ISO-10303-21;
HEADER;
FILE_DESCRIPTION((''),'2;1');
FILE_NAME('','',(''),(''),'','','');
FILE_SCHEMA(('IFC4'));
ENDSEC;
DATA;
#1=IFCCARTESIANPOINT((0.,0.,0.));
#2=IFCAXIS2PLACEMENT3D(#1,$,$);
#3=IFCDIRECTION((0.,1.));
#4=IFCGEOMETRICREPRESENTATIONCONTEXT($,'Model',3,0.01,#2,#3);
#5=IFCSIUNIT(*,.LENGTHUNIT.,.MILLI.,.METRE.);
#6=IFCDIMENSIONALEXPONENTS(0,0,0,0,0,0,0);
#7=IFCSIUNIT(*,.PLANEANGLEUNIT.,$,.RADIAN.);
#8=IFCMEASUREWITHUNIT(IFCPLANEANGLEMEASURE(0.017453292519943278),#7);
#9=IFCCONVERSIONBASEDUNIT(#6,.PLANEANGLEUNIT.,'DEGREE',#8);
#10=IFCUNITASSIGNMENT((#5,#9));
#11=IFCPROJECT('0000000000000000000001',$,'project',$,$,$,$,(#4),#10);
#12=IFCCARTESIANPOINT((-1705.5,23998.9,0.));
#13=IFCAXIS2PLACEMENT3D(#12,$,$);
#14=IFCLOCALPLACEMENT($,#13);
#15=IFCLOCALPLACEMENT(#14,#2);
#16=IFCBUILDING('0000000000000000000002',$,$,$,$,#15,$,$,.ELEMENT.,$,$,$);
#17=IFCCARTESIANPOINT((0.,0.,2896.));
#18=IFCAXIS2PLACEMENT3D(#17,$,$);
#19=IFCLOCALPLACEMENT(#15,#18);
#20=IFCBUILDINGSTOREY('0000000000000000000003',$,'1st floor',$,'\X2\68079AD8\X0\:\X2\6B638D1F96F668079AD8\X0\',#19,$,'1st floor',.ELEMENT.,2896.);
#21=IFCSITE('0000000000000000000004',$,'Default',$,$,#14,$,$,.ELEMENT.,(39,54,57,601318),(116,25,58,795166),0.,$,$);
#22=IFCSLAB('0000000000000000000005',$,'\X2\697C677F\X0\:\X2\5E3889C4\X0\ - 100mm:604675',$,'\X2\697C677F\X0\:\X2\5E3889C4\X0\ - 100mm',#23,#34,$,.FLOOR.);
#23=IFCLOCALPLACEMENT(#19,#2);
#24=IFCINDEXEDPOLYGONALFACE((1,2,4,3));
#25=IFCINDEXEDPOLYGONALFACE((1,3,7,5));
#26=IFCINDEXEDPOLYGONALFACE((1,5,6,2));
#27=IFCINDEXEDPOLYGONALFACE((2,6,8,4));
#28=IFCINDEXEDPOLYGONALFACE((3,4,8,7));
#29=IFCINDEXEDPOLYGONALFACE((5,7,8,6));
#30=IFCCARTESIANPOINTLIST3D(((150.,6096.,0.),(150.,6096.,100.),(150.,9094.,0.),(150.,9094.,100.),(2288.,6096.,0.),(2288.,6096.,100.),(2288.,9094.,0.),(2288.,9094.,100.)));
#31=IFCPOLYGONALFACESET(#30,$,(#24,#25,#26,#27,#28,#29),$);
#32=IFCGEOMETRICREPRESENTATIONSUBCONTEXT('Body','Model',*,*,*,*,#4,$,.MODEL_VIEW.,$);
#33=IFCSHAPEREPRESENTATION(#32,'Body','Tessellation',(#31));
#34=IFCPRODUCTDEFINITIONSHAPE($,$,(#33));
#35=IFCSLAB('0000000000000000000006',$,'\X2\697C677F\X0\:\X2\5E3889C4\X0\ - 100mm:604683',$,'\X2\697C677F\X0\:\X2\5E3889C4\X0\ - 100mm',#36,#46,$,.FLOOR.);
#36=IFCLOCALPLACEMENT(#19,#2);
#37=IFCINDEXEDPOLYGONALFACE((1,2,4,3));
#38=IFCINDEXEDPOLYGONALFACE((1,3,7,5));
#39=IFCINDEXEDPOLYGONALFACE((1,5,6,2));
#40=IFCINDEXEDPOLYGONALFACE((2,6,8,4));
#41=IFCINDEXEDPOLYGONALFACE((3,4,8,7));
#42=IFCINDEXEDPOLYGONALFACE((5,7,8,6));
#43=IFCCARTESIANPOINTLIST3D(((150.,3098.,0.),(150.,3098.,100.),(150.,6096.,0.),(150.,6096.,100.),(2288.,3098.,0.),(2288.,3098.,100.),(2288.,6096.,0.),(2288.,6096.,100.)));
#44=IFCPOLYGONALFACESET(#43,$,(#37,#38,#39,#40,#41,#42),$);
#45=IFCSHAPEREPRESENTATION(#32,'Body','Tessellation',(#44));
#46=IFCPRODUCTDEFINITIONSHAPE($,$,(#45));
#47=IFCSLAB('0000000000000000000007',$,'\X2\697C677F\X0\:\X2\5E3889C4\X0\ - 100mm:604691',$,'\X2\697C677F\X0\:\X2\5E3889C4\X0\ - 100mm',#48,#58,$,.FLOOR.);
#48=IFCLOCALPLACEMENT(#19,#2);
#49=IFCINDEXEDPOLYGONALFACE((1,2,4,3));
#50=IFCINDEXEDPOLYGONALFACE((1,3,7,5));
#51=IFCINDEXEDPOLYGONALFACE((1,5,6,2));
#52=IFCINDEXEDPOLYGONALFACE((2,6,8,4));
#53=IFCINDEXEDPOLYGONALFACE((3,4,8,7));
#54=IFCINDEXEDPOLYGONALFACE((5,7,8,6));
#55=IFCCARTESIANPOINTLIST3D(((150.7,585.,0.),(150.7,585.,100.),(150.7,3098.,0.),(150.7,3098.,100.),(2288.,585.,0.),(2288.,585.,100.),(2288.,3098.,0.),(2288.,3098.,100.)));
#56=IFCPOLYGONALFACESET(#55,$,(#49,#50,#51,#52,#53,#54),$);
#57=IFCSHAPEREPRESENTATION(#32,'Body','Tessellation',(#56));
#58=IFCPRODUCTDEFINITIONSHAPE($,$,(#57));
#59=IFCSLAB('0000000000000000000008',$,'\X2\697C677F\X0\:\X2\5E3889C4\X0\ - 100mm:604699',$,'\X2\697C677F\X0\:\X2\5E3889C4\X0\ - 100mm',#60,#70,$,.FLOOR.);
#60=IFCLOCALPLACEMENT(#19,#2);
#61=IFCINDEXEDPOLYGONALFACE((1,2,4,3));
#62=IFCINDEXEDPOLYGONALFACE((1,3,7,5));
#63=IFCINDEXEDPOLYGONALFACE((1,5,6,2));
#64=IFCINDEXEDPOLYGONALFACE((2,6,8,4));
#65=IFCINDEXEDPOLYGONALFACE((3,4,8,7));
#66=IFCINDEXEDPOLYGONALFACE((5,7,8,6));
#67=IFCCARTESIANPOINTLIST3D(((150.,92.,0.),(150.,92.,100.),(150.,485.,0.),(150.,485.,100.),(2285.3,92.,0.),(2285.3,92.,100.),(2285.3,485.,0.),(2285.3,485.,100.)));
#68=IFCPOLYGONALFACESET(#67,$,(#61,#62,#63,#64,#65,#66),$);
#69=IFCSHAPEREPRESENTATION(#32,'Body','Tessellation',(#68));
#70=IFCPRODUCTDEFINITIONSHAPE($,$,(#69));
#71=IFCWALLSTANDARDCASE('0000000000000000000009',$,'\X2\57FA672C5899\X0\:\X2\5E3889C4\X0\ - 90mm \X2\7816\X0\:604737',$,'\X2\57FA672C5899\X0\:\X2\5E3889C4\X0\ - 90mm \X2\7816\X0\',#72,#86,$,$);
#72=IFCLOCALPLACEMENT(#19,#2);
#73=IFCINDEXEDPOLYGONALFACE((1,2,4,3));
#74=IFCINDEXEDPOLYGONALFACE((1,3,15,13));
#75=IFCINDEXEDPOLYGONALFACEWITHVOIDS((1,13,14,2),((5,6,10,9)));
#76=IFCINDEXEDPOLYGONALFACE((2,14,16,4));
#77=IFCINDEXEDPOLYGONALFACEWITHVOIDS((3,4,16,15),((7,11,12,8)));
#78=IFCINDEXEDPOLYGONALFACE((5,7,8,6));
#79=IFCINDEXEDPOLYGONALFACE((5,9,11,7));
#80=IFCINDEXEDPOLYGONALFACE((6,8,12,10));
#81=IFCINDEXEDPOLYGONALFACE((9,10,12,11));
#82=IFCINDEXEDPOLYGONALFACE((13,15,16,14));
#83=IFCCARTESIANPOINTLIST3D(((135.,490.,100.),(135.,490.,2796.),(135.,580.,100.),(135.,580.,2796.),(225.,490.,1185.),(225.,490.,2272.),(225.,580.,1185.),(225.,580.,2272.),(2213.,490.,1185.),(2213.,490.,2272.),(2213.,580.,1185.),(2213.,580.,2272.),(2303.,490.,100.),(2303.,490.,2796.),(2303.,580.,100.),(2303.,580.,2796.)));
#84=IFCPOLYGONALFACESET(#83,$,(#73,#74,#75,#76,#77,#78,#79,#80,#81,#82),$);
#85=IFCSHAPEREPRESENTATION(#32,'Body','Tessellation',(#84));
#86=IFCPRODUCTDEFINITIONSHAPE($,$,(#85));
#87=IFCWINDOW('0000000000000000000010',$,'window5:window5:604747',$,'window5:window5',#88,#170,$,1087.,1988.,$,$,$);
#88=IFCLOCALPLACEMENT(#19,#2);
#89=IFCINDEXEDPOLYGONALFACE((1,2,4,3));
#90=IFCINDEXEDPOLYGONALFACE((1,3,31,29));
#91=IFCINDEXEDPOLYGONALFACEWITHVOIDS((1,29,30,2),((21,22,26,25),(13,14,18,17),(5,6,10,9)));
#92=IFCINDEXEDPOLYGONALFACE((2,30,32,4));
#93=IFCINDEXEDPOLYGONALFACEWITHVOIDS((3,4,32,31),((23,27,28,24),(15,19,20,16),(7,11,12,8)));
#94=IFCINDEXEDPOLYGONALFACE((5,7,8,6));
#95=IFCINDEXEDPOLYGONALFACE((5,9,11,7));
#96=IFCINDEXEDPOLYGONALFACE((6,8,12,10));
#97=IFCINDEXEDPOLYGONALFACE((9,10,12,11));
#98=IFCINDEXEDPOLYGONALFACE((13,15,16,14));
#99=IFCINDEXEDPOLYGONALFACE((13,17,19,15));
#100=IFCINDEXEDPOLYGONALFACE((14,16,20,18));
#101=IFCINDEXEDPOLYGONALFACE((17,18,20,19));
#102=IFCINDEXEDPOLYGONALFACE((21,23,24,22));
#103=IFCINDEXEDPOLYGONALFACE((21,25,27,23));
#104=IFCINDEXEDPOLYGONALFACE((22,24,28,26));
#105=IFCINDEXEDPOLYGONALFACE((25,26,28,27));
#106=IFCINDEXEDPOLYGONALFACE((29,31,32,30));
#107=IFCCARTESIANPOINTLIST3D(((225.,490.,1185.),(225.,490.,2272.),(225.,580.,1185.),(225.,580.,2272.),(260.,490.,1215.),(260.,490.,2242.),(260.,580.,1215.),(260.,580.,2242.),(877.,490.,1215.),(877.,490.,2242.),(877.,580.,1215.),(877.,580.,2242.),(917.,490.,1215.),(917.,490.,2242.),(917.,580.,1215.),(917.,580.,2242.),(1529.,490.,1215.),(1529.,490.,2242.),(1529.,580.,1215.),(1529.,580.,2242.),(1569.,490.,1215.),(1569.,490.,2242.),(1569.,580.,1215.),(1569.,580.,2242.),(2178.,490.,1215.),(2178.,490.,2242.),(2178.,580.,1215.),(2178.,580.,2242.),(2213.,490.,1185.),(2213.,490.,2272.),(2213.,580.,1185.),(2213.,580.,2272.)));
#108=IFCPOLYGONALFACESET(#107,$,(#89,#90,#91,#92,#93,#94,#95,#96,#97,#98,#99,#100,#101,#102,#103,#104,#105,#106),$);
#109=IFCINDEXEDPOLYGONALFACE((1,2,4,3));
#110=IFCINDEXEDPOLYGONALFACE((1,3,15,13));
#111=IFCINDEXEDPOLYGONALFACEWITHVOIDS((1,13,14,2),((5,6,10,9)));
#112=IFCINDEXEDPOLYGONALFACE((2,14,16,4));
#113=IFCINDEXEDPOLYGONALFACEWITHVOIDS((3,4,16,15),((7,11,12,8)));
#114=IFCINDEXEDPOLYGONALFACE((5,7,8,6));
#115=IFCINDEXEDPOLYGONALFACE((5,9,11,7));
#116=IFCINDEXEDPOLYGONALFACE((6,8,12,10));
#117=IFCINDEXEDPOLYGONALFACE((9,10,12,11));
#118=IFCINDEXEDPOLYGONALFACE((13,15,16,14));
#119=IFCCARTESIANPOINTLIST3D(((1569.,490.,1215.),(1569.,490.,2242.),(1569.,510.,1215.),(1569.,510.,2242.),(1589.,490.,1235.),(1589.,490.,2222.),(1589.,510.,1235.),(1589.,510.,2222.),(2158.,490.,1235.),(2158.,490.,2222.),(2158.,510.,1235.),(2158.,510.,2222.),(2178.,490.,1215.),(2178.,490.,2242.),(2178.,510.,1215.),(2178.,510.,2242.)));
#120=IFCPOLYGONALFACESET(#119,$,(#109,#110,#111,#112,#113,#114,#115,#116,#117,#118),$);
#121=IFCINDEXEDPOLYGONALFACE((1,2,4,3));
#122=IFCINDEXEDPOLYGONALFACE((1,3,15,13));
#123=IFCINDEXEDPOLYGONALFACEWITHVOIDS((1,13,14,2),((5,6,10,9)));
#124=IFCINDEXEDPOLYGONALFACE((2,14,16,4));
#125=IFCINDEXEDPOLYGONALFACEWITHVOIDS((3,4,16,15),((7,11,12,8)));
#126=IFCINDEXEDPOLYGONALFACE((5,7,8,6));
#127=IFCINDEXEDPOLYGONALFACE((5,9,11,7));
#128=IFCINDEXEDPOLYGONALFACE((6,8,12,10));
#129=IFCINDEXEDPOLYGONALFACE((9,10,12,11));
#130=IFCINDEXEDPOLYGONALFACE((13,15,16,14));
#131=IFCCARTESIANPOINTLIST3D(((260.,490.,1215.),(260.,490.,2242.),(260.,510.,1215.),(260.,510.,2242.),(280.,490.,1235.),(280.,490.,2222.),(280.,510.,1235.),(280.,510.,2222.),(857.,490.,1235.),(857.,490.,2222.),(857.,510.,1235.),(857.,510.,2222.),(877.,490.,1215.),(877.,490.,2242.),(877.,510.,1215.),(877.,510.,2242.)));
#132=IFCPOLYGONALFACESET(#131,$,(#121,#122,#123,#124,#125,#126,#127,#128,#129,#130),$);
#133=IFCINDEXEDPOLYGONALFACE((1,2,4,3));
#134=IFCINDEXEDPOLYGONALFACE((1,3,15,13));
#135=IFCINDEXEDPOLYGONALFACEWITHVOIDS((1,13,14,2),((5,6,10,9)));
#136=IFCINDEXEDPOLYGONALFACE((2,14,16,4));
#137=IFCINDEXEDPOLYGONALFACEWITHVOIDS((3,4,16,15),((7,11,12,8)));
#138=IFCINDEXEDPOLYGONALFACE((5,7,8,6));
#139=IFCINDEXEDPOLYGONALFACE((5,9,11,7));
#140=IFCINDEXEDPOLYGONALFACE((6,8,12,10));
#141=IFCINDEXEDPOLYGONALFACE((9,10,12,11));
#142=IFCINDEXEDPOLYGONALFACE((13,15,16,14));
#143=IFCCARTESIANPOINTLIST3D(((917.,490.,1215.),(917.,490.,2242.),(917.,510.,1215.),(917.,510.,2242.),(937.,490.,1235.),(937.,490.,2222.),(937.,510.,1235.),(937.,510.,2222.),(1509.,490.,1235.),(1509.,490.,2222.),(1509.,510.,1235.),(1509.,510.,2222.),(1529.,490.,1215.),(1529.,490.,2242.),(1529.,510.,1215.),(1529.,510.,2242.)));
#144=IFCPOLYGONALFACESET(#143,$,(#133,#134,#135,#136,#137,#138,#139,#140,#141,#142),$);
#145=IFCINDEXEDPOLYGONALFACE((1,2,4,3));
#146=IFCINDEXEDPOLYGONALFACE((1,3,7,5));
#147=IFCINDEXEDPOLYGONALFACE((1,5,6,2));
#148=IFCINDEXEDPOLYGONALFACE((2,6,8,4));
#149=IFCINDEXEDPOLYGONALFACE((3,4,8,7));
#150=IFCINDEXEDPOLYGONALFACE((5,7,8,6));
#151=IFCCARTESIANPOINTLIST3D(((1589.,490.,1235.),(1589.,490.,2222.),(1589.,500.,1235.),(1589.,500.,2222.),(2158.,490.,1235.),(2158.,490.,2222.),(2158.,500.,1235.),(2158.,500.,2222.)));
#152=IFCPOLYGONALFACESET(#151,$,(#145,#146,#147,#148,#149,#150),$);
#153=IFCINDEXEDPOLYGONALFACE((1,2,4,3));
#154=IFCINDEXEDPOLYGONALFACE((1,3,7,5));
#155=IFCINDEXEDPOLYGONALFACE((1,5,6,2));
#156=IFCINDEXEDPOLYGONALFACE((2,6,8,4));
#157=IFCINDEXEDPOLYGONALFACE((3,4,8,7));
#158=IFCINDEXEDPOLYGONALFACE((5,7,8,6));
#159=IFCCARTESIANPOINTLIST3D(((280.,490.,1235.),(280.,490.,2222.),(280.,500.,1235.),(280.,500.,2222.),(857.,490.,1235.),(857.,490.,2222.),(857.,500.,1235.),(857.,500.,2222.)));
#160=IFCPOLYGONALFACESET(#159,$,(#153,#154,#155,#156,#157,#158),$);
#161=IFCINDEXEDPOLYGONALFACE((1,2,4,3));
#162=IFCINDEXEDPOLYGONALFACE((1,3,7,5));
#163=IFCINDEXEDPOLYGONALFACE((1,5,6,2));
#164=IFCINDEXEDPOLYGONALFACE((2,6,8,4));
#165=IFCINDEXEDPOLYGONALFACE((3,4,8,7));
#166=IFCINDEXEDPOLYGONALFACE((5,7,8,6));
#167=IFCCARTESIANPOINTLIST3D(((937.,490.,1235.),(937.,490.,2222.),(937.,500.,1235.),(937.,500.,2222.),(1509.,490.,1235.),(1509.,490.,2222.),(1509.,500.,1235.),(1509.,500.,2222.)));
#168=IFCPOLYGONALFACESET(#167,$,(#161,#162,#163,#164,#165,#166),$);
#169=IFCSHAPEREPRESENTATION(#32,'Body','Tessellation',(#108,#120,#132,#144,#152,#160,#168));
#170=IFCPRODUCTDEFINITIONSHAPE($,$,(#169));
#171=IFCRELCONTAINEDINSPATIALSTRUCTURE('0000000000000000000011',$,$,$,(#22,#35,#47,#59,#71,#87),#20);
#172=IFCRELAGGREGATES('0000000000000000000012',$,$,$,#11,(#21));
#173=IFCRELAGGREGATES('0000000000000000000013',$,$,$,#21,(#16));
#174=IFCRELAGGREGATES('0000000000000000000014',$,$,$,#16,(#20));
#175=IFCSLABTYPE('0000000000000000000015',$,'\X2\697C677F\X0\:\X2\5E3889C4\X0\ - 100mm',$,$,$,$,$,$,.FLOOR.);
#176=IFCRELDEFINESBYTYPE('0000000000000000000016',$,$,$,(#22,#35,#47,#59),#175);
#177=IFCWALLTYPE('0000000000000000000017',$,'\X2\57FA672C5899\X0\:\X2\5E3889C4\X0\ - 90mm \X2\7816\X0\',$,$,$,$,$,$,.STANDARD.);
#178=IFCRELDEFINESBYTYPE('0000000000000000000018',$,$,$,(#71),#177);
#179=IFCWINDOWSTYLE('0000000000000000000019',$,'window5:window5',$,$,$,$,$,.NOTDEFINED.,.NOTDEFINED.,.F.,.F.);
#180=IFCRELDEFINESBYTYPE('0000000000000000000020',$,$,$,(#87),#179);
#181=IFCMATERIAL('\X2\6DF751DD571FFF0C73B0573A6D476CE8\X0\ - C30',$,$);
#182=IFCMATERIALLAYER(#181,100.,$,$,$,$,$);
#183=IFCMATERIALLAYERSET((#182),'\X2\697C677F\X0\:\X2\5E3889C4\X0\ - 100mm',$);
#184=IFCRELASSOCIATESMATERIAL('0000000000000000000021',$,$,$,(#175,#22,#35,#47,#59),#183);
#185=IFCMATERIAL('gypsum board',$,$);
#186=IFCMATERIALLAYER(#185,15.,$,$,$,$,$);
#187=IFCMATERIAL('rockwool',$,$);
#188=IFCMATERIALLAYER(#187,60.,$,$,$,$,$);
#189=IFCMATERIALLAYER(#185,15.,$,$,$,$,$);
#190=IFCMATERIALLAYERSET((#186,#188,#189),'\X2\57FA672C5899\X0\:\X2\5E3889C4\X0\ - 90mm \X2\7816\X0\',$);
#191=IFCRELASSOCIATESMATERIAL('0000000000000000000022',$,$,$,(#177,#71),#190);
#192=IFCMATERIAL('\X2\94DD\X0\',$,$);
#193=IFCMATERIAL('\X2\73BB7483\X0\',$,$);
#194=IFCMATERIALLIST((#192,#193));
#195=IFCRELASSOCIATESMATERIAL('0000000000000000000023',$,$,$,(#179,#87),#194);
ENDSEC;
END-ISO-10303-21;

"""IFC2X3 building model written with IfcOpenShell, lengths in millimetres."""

from ifc_helpers import new_model, entity, si_unit, converted_unit, direction, frame, frame_2d, origin, origin_2d_with_axis, place, context, subcontext, project, spatial, polyline, rectangle, outline, extrude, source, transform, mapped, material, material_list, layer, layer_set, layer_usage, type_object, type_shapes, element, fill, save


model = new_model("IFC2X3")

# Units and contexts
model_context = context("Model", 3, precision=0.01, world=origin(), true_north=direction((0.0, 1.0)))
body_context = subcontext(model_context, "Body", "Model", "MODEL_VIEW")
ifc_project = project(units=[si_unit("LENGTHUNIT", "METRE", prefix="MILLI"), converted_unit("PLANEANGLEUNIT", "DEGREE", entity("IfcPlaneAngleMeasure", 0.017453292519943278), si_unit("PLANEANGLEUNIT", "RADIAN"), dimensions=[0, 0, 0, 0, 0, 0, 0])], contexts=[model_context])

# Site, building, storey
site_placement = place(None, frame((-1705.5, 23998.9, 0.0)))
site = spatial("IfcSite", under=ifc_project, at=site_placement, Name="Default", CompositionType="ELEMENT", RefLatitude=(39, 54, 57, 601318), RefLongitude=(116, 25, 58, 795166), RefElevation=0.0)
building_placement = place(site_placement, origin())
building = spatial("IfcBuilding", under=site, at=building_placement, CompositionType="ELEMENT")
storey_placement = place(building_placement, frame((0.0, 0.0, 2896.0)))
storey = spatial("IfcBuildingStorey", under=building, at=storey_placement, Name="1st floor", ObjectType="标高:正负零标高", LongName="1st floor", CompositionType="ELEMENT", Elevation=2896.0)

# Slabs
ifc_material_1 = material(Name="混凝土，现场浇注 - C30")
ifc_layer_1 = layer(ifc_material_1, 100.0)
ifc_layer_set_1 = layer_set([ifc_layer_1], Name="楼板:常规 - 100mm")
slab_type = type_object("IfcSlabType", Name="楼板:常规 - 100mm", PredefinedType="FLOOR", material=ifc_layer_set_1)
ifc_layer_usage_1 = layer_usage(ifc_layer_set_1, "AXIS3", "POSITIVE", 0.0)
slab_1_placement = place(storey_placement, origin())
element("IfcSlab", 1, at=slab_1_placement, inside=storey, type_object=slab_type, material=ifc_layer_usage_1, Name="楼板:常规 - 100mm:604675", ObjectType="楼板:常规 - 100mm", PredefinedType="FLOOR", context=body_context, shape_type="SweptSolid", body=[
    extrude(rectangle(XDim=2998.0, YDim=2138.0, at=origin_2d_with_axis()), frame((1219.0, 7595.0, 100.0), z_axis=(0.0, 0.0, -1.0), x_axis=(0.0, 1.0, 0.0)), (0.0, 0.0, 1.0), 100.0),
])
ifc_layer_usage_2 = layer_usage(ifc_layer_set_1, "AXIS3", "POSITIVE", 0.0)
slab_2_placement = place(storey_placement, origin())
element("IfcSlab", 2, at=slab_2_placement, inside=storey, type_object=slab_type, material=ifc_layer_usage_2, Name="楼板:常规 - 100mm:604683", ObjectType="楼板:常规 - 100mm", PredefinedType="FLOOR", context=body_context, shape_type="SweptSolid", body=[
    extrude(rectangle(XDim=2998.0, YDim=2138.0, at=frame_2d((0.0, 0.0), x_axis=(1.0, 0.0))), frame((1219.0, 4597.0, 100.0), z_axis=(0.0, 0.0, -1.0), x_axis=(0.0, 1.0, 0.0)), (0.0, 0.0, 1.0), 100.0),
])
ifc_layer_usage_3 = layer_usage(ifc_layer_set_1, "AXIS3", "POSITIVE", 0.0)
slab_3_placement = place(storey_placement, origin())
element("IfcSlab", 3, at=slab_3_placement, inside=storey, type_object=slab_type, material=ifc_layer_usage_3, Name="楼板:常规 - 100mm:604691", ObjectType="楼板:常规 - 100mm", PredefinedType="FLOOR", context=body_context, shape_type="SweptSolid", body=[
    extrude(rectangle(XDim=2513.0, YDim=2137.3, at=origin_2d_with_axis()), frame((1219.3, 1841.5, 100.0), z_axis=(0.0, 0.0, -1.0), x_axis=(0.0, 1.0, 0.0)), (0.0, 0.0, 1.0), 100.0),
])
ifc_layer_usage_4 = layer_usage(ifc_layer_set_1, "AXIS3", "POSITIVE", 0.0)
slab_4_placement = place(storey_placement, origin())
element("IfcSlab", 4, at=slab_4_placement, inside=storey, type_object=slab_type, material=ifc_layer_usage_4, Name="楼板:常规 - 100mm:604699", ObjectType="楼板:常规 - 100mm", PredefinedType="FLOOR", context=body_context, shape_type="SweptSolid", body=[
    extrude(rectangle(XDim=393.0, YDim=2135.3, at=frame_2d((0.0, 0.0), x_axis=(1.0, 0.0))), frame((1217.7, 288.5, 100.0), z_axis=(0.0, 0.0, -1.0), x_axis=(0.0, 1.0, 0.0)), (0.0, 0.0, 1.0), 100.0),
])

# Wall, opening, window
ifc_material_2 = material(Name="gypsum board")
ifc_layer_2 = layer(ifc_material_2, 15.0)
ifc_material_3 = material(Name="rockwool")
ifc_layer_3 = layer(ifc_material_3, 60.0)
ifc_layer_4 = layer(ifc_material_2, 15.0)
ifc_layer_set_2 = layer_set([ifc_layer_2, ifc_layer_3, ifc_layer_4], Name="基本墙:常规 - 90mm 砖")
ifc_layer_usage_5 = layer_usage(ifc_layer_set_2, "AXIS2", "NEGATIVE", 45.0)
wall_type = type_object("IfcWallType", Name="基本墙:常规 - 90mm 砖", PredefinedType="STANDARD", material=ifc_layer_set_2)
wall_placement = place(storey_placement, frame((2303.0, 535.0, 100.0), z_axis=(0.0, 0.0, 1.0), x_axis=(-1.0, 0.0, 0.0)))
wall = element("IfcWallStandardCase", 5, at=wall_placement, inside=storey, type_object=wall_type, material=ifc_layer_usage_5, Name="基本墙:常规 - 90mm 砖:604737", ObjectType="基本墙:常规 - 90mm 砖", context=body_context, shape_type="SweptSolid", body=[
    extrude(rectangle(XDim=2168.0, YDim=90.0, at=frame_2d((1084.0, 0.0), x_axis=(-1.0, 0.0))), origin(), (0.0, 0.0, 1.0), 2696.0),
])
opening_1_placement = place(wall_placement, frame((90.0, -45.0, 1085.0)))
opening_1 = element("IfcOpeningElement", 6, at=opening_1_placement, cuts=wall, ObjectType="Opening", context=body_context, shape_type="SweptSolid", body=[
    extrude(rectangle(XDim=1087.0, YDim=1988.0, at=frame_2d((543.5, 994.0), x_axis=(1.0, 0.0))), frame((0.0, 0.0, 0.0), z_axis=(0.0, 1.0, 0.0), x_axis=(0.0, 0.0, 1.0)), (0.0, 0.0, 1.0), 90.0),
])
ifc_material_4 = material(Name="铝")
ifc_material_5 = material(Name="玻璃")
ifc_material_list = material_list([ifc_material_4, ifc_material_5])
window_style = type_object("IfcWindowStyle", Name="window5:window5", ConstructionType="NOTDEFINED", OperationType="NOTDEFINED", ParameterTakesPrecedence=False, Sizeable=False, material=ifc_material_list)
shared_shape = source(origin(), body_context, "Body", "SweptSolid", [
    extrude(outline(polyline([(-994.0, -543.5), (994.0, -543.5), (994.0, 543.5), (-994.0, 543.5), (-994.0, -543.5)]), holes=[polyline([(-959.0, 513.5), (-342.0, 513.5), (-342.0, -513.5), (-959.0, -513.5), (-959.0, 513.5)]), polyline([(-302.0, 513.5), (310.0, 513.5), (310.0, -513.5), (-302.0, -513.5), (-302.0, 513.5)]), polyline([(350.0, 513.5), (959.0, 513.5), (959.0, -513.5), (350.0, -513.5), (350.0, 513.5)])]), frame((994.0, 0.0, 543.5), z_axis=(0.0, 1.0, 0.0), x_axis=(-1.0, 0.0, 0.0)), (0.0, 0.0, 1.0), 90.0),
    extrude(outline(polyline([(-304.5, -513.5), (304.5, -513.5), (304.5, 513.5), (-304.5, 513.5), (-304.5, -513.5)]), holes=[polyline([(-284.5, -493.5), (-284.5, 493.5), (284.5, 493.5), (284.5, -493.5), (-284.5, -493.5)])]), frame((339.5, 70.0, 543.5), z_axis=(0.0, 1.0, 0.0), x_axis=(1.0, 0.0, 0.0)), (0.0, 0.0, 1.0), 20.0),
    extrude(outline(polyline([(-308.5, -513.5), (308.5, -513.5), (308.5, 513.5), (-308.5, 513.5), (-308.5, -513.5)]), holes=[polyline([(-288.5, -493.5), (-288.5, 493.5), (288.5, 493.5), (288.5, -493.5), (-288.5, -493.5)])]), frame((1644.5, 70.0, 543.5), z_axis=(0.0, 1.0, 0.0), x_axis=(1.0, 0.0, 0.0)), (0.0, 0.0, 1.0), 20.0),
    extrude(outline(polyline([(-306.0, -513.5), (306.0, -513.5), (306.0, 513.5), (-306.0, 513.5), (-306.0, -513.5)]), holes=[polyline([(-286.0, -493.5), (-286.0, 493.5), (286.0, 493.5), (286.0, -493.5), (-286.0, -493.5)])]), frame((990.0, 70.0, 543.5), z_axis=(0.0, 1.0, 0.0), x_axis=(1.0, 0.0, 0.0)), (0.0, 0.0, 1.0), 20.0),
    extrude(rectangle(XDim=10.0, YDim=569.0, at=frame_2d((0.0, 0.0), x_axis=(1.0, 0.0))), frame((339.5, 85.0, 50.0), z_axis=(0.0, 0.0, 1.0), x_axis=(0.0, 1.0, 0.0)), (0.0, 0.0, 1.0), 987.0),
    extrude(rectangle(XDim=10.0, YDim=577.0, at=frame_2d((0.0, 0.0), x_axis=(1.0, 0.0))), frame((1644.5, 85.0, 50.0), z_axis=(0.0, 0.0, 1.0), x_axis=(0.0, 1.0, 0.0)), (0.0, 0.0, 1.0), 987.0),
    extrude(rectangle(XDim=10.0, YDim=572.0, at=frame_2d((0.0, 0.0), x_axis=(1.0, 0.0))), frame((990.0, 85.0, 50.0), z_axis=(0.0, 0.0, 1.0), x_axis=(0.0, 1.0, 0.0)), (0.0, 0.0, 1.0), 987.0),
])
type_shapes(window_style, [shared_shape])
window_placement = place(opening_1_placement, origin())
window = element("IfcWindow", 7, at=window_placement, inside=storey, type_object=window_style, material=ifc_material_list, Name="window5:window5:604747", ObjectType="window5:window5", OverallHeight=1087.0, OverallWidth=1988.0, context=body_context, shape_type="MappedRepresentation", body=[
    mapped(shared_shape, transform((0.0, 0.0, 0.0), scale=1.0)),
])
fill(opening_1, window)

save(model, "model.ifc")
